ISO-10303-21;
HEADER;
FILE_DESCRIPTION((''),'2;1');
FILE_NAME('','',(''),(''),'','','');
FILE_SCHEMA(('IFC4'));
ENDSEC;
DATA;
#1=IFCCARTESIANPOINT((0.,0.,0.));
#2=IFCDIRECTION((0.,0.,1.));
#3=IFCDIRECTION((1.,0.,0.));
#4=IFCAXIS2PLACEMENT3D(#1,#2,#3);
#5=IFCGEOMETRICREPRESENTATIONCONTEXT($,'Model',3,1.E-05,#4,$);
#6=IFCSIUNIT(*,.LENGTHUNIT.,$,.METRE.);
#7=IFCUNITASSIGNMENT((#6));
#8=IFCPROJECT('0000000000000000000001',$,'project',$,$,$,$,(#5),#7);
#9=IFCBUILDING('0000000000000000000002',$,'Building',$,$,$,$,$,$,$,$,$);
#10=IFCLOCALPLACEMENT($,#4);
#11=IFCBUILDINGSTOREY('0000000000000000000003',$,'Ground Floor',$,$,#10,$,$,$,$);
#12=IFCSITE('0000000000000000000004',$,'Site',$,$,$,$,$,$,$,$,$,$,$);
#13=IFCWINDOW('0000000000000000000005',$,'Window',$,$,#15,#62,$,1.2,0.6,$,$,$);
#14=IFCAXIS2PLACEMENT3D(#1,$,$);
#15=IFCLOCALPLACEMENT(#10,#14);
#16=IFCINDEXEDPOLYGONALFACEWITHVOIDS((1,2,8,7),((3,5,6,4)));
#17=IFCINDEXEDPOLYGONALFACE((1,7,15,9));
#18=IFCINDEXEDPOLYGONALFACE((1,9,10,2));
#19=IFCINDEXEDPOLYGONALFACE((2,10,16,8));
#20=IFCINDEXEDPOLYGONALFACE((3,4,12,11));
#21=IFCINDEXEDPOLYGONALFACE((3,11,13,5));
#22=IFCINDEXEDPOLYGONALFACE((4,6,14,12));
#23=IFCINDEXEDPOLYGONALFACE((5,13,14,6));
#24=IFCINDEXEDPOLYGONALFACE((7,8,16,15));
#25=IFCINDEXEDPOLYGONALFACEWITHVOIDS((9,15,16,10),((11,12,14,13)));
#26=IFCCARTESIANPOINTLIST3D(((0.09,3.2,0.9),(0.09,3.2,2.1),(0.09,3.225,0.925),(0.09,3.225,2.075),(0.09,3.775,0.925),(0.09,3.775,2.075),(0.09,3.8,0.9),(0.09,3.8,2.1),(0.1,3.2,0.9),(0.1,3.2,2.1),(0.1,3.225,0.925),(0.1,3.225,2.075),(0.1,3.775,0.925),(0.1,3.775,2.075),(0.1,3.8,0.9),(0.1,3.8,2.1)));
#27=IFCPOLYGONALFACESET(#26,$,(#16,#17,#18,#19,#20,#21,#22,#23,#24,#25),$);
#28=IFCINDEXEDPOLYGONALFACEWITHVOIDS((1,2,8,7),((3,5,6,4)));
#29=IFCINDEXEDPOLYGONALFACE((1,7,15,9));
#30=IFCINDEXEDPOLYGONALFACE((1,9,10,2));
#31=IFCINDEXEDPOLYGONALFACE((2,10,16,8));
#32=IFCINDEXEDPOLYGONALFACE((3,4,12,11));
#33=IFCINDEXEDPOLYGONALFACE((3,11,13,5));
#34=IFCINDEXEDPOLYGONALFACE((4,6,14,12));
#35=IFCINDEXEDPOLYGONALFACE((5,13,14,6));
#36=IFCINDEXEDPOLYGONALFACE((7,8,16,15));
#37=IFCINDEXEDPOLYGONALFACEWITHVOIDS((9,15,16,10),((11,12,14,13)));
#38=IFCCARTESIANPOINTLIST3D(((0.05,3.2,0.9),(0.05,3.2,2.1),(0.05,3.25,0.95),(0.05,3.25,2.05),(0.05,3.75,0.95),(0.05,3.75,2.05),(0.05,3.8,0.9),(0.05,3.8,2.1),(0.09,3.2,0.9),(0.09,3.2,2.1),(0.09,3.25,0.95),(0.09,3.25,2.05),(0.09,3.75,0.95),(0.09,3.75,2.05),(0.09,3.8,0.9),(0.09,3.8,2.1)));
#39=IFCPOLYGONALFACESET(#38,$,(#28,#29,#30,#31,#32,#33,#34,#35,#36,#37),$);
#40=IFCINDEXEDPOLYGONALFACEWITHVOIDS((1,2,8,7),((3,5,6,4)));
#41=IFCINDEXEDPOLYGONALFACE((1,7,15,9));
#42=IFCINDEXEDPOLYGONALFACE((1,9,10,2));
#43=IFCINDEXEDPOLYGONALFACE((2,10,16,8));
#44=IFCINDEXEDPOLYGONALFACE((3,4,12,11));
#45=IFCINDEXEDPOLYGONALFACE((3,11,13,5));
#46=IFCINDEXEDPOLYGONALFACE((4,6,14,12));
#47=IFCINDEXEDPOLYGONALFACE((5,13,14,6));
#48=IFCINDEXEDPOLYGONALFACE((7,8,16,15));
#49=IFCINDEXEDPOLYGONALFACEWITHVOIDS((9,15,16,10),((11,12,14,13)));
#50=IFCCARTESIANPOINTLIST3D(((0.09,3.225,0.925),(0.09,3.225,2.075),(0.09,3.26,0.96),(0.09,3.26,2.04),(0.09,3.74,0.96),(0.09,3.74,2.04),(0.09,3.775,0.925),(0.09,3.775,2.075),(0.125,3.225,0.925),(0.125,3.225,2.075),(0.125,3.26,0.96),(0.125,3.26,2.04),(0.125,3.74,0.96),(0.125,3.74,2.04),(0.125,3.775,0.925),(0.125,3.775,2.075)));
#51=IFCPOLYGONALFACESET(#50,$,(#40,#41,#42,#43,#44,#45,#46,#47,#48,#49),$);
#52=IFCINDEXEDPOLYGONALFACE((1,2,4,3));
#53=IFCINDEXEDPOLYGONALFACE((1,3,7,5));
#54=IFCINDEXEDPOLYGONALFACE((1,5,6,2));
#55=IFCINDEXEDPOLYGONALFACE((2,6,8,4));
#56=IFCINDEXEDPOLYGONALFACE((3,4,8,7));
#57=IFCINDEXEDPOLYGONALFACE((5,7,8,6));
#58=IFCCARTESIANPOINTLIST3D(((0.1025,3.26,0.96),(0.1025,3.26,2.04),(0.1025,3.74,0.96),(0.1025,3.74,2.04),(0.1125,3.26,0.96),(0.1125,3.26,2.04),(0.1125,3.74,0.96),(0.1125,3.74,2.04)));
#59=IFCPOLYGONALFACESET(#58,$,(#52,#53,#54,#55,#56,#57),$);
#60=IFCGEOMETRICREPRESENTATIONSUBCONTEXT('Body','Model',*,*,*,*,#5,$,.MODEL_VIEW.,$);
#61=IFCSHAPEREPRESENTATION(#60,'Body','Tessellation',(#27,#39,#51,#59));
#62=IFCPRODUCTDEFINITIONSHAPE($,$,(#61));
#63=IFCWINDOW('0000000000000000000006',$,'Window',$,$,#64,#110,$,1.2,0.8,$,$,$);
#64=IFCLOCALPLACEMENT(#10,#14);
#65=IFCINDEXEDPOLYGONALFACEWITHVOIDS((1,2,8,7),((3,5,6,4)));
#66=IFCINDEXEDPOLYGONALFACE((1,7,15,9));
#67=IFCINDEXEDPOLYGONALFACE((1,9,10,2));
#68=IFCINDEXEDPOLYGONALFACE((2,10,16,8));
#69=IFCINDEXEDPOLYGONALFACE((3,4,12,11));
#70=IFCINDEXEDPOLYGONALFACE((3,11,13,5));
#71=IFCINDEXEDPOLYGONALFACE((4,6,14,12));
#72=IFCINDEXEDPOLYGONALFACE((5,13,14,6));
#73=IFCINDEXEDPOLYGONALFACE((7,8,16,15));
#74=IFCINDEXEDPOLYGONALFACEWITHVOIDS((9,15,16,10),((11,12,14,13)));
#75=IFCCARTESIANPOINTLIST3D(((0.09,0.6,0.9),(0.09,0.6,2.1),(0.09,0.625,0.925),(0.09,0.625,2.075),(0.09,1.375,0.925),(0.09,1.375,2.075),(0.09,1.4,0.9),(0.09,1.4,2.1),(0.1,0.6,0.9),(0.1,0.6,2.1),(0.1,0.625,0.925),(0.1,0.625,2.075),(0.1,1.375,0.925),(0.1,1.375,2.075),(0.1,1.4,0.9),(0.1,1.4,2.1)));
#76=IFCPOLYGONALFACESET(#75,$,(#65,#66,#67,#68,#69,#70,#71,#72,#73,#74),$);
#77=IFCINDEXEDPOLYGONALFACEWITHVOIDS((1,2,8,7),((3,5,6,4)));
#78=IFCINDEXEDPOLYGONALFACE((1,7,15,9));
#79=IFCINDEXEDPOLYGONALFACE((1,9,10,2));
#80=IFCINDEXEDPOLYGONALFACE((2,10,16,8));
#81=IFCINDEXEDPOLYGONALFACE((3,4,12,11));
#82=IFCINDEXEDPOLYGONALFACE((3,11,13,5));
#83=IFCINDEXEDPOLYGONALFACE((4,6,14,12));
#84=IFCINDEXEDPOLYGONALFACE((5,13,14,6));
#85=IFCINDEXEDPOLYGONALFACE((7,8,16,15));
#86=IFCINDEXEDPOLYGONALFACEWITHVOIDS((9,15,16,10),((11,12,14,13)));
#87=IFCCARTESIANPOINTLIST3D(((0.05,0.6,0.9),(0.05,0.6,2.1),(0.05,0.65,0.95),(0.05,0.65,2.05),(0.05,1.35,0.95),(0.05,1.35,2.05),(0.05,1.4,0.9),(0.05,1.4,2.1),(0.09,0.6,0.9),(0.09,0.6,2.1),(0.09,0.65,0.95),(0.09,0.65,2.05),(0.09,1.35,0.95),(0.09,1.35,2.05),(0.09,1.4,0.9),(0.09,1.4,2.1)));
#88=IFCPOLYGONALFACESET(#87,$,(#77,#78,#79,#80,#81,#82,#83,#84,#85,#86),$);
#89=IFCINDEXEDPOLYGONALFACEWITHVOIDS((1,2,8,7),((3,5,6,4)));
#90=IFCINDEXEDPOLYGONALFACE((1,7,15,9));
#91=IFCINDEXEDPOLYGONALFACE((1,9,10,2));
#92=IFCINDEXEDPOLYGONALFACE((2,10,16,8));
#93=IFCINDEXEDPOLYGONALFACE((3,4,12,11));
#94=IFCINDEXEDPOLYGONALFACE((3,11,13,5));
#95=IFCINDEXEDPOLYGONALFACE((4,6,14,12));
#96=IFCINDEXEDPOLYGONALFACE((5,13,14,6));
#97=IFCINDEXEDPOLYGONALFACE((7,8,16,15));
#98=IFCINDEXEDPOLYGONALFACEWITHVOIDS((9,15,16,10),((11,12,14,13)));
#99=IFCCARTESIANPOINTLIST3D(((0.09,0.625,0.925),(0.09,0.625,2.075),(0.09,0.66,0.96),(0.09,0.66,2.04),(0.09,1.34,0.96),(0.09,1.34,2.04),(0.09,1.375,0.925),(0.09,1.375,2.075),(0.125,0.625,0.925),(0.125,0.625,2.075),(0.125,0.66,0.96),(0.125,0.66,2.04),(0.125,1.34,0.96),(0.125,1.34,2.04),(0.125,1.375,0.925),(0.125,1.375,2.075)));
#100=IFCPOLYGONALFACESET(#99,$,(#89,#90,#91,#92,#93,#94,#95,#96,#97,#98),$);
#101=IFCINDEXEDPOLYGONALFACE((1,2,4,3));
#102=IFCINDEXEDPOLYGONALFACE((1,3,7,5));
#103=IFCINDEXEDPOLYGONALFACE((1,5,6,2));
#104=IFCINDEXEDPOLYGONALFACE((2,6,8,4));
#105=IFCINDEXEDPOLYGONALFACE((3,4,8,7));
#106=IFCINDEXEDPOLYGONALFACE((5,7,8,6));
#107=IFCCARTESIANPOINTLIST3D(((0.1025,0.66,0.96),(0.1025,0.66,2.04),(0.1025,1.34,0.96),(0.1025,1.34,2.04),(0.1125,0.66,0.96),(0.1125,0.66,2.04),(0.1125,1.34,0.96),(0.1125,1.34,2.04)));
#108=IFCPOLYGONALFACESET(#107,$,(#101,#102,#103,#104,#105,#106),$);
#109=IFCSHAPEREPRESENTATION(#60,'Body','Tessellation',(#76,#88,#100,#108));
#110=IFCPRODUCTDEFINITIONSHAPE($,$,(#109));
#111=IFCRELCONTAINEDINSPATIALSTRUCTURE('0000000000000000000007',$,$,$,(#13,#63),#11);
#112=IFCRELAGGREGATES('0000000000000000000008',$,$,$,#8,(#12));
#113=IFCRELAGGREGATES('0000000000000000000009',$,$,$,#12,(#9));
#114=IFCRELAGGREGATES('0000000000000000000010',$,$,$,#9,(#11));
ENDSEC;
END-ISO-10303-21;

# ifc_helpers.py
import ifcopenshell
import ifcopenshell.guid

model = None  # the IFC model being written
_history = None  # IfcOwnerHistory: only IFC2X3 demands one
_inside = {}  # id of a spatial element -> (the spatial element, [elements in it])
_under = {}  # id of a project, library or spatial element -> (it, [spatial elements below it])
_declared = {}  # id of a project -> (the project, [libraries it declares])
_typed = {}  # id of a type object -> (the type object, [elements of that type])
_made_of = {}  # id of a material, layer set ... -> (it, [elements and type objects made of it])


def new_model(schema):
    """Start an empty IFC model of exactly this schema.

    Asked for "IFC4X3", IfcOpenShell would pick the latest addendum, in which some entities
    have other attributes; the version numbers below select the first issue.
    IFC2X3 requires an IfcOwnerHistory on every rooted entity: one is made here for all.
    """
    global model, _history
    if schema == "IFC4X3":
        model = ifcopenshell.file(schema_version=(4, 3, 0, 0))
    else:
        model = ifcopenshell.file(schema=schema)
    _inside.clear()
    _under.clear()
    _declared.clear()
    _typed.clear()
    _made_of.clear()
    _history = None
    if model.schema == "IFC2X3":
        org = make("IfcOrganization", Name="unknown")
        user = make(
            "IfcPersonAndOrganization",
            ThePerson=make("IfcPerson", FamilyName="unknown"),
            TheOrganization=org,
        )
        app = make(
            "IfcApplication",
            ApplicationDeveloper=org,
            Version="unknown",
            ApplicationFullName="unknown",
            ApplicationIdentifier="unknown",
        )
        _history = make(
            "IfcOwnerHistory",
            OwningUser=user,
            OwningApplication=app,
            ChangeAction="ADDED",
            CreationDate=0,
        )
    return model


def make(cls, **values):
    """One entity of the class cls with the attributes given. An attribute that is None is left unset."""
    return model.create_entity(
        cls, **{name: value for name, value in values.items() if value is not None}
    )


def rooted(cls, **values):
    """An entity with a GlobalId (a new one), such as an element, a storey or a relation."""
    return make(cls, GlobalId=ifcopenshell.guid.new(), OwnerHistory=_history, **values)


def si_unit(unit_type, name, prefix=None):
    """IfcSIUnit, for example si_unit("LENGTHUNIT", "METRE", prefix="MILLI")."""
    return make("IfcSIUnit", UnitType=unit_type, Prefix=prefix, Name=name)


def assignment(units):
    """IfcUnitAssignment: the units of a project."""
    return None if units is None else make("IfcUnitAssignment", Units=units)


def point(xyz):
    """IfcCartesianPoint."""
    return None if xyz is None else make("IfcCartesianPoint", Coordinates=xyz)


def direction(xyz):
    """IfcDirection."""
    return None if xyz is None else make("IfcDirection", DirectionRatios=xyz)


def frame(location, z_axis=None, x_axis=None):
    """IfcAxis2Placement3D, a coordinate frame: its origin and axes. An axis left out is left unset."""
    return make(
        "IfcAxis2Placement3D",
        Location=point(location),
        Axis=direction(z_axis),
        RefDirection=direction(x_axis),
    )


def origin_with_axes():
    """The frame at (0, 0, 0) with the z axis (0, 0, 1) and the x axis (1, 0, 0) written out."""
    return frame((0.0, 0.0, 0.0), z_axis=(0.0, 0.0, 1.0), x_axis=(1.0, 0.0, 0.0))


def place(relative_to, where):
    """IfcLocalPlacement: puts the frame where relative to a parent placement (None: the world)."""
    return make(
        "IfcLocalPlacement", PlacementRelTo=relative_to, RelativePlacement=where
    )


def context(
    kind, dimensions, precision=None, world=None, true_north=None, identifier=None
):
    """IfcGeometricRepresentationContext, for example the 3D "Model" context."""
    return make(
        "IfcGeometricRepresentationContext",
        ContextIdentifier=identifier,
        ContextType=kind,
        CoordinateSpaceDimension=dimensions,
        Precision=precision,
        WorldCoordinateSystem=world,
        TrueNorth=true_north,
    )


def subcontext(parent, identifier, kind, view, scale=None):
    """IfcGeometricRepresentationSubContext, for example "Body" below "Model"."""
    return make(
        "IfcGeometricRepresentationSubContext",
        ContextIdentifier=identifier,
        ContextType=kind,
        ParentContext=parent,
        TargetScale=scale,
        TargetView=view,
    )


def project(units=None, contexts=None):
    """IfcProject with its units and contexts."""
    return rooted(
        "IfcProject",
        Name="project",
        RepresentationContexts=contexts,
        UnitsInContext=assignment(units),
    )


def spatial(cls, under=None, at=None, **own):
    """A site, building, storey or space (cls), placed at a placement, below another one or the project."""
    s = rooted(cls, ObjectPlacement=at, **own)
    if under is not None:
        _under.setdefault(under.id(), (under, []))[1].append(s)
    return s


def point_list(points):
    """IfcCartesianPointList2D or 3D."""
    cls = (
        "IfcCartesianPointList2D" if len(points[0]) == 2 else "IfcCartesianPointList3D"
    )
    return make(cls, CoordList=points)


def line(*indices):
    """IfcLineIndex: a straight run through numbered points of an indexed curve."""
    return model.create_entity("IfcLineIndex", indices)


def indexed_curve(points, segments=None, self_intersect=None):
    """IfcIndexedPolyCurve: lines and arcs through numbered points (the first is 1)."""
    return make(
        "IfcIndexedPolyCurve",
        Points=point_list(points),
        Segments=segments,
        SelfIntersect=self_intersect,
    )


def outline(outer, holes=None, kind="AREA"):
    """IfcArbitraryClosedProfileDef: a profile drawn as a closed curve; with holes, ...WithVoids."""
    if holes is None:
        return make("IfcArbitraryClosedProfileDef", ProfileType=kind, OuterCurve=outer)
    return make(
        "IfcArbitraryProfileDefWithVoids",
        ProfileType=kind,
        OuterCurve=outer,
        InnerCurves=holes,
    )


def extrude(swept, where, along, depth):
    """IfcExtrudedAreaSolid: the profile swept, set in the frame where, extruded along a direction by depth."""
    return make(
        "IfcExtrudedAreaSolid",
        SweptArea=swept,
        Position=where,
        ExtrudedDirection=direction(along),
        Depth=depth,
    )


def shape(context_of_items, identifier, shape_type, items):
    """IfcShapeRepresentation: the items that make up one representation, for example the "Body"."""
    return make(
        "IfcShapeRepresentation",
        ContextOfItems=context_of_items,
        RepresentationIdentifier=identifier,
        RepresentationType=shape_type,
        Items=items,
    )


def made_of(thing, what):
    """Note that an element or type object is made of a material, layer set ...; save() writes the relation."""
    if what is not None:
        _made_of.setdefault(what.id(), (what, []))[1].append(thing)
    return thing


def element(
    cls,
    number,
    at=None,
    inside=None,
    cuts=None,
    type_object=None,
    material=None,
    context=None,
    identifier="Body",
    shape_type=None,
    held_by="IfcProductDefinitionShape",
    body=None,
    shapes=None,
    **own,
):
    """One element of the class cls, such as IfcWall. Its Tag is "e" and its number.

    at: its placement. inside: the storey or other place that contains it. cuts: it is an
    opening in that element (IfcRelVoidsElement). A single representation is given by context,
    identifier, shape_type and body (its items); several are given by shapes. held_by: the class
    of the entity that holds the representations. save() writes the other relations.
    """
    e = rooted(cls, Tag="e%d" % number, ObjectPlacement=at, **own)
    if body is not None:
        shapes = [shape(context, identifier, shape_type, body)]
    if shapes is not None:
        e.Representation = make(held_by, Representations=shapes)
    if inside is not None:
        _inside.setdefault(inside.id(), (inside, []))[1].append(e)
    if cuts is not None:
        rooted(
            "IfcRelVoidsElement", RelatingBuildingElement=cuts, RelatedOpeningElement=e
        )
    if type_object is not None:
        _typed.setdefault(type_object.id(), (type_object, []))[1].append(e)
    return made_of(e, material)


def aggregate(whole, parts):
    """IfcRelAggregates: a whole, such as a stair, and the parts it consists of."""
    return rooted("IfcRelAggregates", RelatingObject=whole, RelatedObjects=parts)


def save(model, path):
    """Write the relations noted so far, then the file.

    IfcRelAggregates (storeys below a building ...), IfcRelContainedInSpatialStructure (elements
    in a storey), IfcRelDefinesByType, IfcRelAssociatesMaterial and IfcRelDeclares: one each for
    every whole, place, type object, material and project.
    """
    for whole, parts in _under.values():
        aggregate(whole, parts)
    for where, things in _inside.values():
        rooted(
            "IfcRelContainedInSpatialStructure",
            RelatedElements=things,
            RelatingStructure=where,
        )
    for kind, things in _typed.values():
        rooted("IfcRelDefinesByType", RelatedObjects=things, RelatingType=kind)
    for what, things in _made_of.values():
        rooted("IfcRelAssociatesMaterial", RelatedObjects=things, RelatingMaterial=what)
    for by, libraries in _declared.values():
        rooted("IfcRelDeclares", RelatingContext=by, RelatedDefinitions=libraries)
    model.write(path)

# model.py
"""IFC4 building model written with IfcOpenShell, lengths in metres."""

from ifc_helpers import new_model, si_unit, frame, origin_with_axes, place, context, subcontext, project, spatial, line, indexed_curve, outline, extrude, element, save


model = new_model("IFC4")

# Units and contexts
model_context = context("Model", 3, precision=1e-05, world=origin_with_axes())
body_context = subcontext(model_context, "Body", "Model", "MODEL_VIEW")
ifc_project = project(units=[si_unit("LENGTHUNIT", "METRE")], contexts=[model_context])

# Site, building, storey
site = spatial("IfcSite", under=ifc_project, Name="Site")
building = spatial("IfcBuilding", under=site, Name="Building")
storey_placement = place(None, origin_with_axes())
storey = spatial("IfcBuildingStorey", under=building, at=storey_placement, Name="Ground Floor")

# Windows
window_1_placement = place(storey_placement, frame((0.0, 3.8, 0.9), z_axis=(0.0, 0.0, 1.0), x_axis=(0.0, -1.0, 0.0)))
element("IfcWindow", 1, at=window_1_placement, inside=storey, Name="Window", OverallHeight=1.2, OverallWidth=0.6, context=body_context, shape_type="SweptSolid", body=[
    extrude(outline(indexed_curve([(0.0, 0.0), (0.6, 0.0), (0.6, 1.2), (0.0, 1.2)], segments=[line(1, 2, 3, 4, 1)]), holes=[indexed_curve([(0.025, 0.025), (0.575, 0.025), (0.575, 1.175), (0.025, 1.175)], segments=[line(1, 2, 3, 4, 1)])]), frame((0.0, 0.09, 0.0), z_axis=(0.0, -1.0, 0.0), x_axis=(1.0, 0.0, 0.0)), (0.0, 0.0, -1.0), 0.01),
    extrude(outline(indexed_curve([(0.0, 0.0), (0.6, 0.0), (0.6, 1.2), (0.0, 1.2)], segments=[line(1, 2, 3, 4, 1)]), holes=[indexed_curve([(0.05, 0.05), (0.55, 0.05), (0.55, 1.15), (0.05, 1.15)], segments=[line(1, 2, 3, 4, 1)])]), frame((0.0, 0.05, 0.0), z_axis=(0.0, -1.0, 0.0), x_axis=(1.0, 0.0, 0.0)), (0.0, 0.0, -1.0), 0.04),
    extrude(outline(indexed_curve([(0.0, 0.0), (0.55, 0.0), (0.55, 1.15), (0.0, 1.15)], segments=[line(1, 2, 3, 4, 1)]), holes=[indexed_curve([(0.035, 0.035), (0.515, 0.035), (0.515, 1.115), (0.035, 1.115)], segments=[line(1, 2, 3, 4, 1)])]), frame((0.025, 0.09, 0.025), z_axis=(0.0, -1.0, 0.0), x_axis=(1.0, 0.0, 0.0)), (0.0, 0.0, -1.0), 0.035),
    extrude(outline(indexed_curve([(0.035, 0.035), (0.515, 0.035), (0.515, 1.115), (0.035, 1.115)], segments=[line(1, 2, 3, 4, 1)])), frame((0.025, 0.1025, 0.025), z_axis=(0.0, -1.0, 0.0), x_axis=(1.0, 0.0, 0.0)), (0.0, 0.0, -1.0), 0.01),
])
window_2_placement = place(storey_placement, frame((0.0, 1.4, 0.9), z_axis=(0.0, 0.0, 1.0), x_axis=(0.0, -1.0, 0.0)))
element("IfcWindow", 2, at=window_2_placement, inside=storey, Name="Window", OverallHeight=1.2, OverallWidth=0.8, context=body_context, shape_type="SweptSolid", body=[
    extrude(outline(indexed_curve([(0.0, 0.0), (0.8, 0.0), (0.8, 1.2), (0.0, 1.2)], segments=[line(1, 2, 3, 4, 1)]), holes=[indexed_curve([(0.025, 0.025), (0.775, 0.025), (0.775, 1.175), (0.025, 1.175)], segments=[line(1, 2, 3, 4, 1)])]), frame((0.0, 0.09, 0.0), z_axis=(0.0, -1.0, 0.0), x_axis=(1.0, 0.0, 0.0)), (0.0, 0.0, -1.0), 0.01),
    extrude(outline(indexed_curve([(0.0, 0.0), (0.8, 0.0), (0.8, 1.2), (0.0, 1.2)], segments=[line(1, 2, 3, 4, 1)]), holes=[indexed_curve([(0.05, 0.05), (0.75, 0.05), (0.75, 1.15), (0.05, 1.15)], segments=[line(1, 2, 3, 4, 1)])]), frame((0.0, 0.05, 0.0), z_axis=(0.0, -1.0, 0.0), x_axis=(1.0, 0.0, 0.0)), (0.0, 0.0, -1.0), 0.04),
    extrude(outline(indexed_curve([(0.0, 0.0), (0.75, 0.0), (0.75, 1.15), (0.0, 1.15)], segments=[line(1, 2, 3, 4, 1)]), holes=[indexed_curve([(0.035, 0.035), (0.715, 0.035), (0.715, 1.115), (0.035, 1.115)], segments=[line(1, 2, 3, 4, 1)])]), frame((0.025, 0.09, 0.025), z_axis=(0.0, -1.0, 0.0), x_axis=(1.0, 0.0, 0.0)), (0.0, 0.0, -1.0), 0.035),
    extrude(outline(indexed_curve([(0.035, 0.035), (0.715, 0.035), (0.715, 1.115), (0.035, 1.115)], segments=[line(1, 2, 3, 4, 1)])), frame((0.025, 0.1025, 0.025), z_axis=(0.0, -1.0, 0.0), x_axis=(1.0, 0.0, 0.0)), (0.0, 0.0, -1.0), 0.01),
])

save(model, "model.ifc")
